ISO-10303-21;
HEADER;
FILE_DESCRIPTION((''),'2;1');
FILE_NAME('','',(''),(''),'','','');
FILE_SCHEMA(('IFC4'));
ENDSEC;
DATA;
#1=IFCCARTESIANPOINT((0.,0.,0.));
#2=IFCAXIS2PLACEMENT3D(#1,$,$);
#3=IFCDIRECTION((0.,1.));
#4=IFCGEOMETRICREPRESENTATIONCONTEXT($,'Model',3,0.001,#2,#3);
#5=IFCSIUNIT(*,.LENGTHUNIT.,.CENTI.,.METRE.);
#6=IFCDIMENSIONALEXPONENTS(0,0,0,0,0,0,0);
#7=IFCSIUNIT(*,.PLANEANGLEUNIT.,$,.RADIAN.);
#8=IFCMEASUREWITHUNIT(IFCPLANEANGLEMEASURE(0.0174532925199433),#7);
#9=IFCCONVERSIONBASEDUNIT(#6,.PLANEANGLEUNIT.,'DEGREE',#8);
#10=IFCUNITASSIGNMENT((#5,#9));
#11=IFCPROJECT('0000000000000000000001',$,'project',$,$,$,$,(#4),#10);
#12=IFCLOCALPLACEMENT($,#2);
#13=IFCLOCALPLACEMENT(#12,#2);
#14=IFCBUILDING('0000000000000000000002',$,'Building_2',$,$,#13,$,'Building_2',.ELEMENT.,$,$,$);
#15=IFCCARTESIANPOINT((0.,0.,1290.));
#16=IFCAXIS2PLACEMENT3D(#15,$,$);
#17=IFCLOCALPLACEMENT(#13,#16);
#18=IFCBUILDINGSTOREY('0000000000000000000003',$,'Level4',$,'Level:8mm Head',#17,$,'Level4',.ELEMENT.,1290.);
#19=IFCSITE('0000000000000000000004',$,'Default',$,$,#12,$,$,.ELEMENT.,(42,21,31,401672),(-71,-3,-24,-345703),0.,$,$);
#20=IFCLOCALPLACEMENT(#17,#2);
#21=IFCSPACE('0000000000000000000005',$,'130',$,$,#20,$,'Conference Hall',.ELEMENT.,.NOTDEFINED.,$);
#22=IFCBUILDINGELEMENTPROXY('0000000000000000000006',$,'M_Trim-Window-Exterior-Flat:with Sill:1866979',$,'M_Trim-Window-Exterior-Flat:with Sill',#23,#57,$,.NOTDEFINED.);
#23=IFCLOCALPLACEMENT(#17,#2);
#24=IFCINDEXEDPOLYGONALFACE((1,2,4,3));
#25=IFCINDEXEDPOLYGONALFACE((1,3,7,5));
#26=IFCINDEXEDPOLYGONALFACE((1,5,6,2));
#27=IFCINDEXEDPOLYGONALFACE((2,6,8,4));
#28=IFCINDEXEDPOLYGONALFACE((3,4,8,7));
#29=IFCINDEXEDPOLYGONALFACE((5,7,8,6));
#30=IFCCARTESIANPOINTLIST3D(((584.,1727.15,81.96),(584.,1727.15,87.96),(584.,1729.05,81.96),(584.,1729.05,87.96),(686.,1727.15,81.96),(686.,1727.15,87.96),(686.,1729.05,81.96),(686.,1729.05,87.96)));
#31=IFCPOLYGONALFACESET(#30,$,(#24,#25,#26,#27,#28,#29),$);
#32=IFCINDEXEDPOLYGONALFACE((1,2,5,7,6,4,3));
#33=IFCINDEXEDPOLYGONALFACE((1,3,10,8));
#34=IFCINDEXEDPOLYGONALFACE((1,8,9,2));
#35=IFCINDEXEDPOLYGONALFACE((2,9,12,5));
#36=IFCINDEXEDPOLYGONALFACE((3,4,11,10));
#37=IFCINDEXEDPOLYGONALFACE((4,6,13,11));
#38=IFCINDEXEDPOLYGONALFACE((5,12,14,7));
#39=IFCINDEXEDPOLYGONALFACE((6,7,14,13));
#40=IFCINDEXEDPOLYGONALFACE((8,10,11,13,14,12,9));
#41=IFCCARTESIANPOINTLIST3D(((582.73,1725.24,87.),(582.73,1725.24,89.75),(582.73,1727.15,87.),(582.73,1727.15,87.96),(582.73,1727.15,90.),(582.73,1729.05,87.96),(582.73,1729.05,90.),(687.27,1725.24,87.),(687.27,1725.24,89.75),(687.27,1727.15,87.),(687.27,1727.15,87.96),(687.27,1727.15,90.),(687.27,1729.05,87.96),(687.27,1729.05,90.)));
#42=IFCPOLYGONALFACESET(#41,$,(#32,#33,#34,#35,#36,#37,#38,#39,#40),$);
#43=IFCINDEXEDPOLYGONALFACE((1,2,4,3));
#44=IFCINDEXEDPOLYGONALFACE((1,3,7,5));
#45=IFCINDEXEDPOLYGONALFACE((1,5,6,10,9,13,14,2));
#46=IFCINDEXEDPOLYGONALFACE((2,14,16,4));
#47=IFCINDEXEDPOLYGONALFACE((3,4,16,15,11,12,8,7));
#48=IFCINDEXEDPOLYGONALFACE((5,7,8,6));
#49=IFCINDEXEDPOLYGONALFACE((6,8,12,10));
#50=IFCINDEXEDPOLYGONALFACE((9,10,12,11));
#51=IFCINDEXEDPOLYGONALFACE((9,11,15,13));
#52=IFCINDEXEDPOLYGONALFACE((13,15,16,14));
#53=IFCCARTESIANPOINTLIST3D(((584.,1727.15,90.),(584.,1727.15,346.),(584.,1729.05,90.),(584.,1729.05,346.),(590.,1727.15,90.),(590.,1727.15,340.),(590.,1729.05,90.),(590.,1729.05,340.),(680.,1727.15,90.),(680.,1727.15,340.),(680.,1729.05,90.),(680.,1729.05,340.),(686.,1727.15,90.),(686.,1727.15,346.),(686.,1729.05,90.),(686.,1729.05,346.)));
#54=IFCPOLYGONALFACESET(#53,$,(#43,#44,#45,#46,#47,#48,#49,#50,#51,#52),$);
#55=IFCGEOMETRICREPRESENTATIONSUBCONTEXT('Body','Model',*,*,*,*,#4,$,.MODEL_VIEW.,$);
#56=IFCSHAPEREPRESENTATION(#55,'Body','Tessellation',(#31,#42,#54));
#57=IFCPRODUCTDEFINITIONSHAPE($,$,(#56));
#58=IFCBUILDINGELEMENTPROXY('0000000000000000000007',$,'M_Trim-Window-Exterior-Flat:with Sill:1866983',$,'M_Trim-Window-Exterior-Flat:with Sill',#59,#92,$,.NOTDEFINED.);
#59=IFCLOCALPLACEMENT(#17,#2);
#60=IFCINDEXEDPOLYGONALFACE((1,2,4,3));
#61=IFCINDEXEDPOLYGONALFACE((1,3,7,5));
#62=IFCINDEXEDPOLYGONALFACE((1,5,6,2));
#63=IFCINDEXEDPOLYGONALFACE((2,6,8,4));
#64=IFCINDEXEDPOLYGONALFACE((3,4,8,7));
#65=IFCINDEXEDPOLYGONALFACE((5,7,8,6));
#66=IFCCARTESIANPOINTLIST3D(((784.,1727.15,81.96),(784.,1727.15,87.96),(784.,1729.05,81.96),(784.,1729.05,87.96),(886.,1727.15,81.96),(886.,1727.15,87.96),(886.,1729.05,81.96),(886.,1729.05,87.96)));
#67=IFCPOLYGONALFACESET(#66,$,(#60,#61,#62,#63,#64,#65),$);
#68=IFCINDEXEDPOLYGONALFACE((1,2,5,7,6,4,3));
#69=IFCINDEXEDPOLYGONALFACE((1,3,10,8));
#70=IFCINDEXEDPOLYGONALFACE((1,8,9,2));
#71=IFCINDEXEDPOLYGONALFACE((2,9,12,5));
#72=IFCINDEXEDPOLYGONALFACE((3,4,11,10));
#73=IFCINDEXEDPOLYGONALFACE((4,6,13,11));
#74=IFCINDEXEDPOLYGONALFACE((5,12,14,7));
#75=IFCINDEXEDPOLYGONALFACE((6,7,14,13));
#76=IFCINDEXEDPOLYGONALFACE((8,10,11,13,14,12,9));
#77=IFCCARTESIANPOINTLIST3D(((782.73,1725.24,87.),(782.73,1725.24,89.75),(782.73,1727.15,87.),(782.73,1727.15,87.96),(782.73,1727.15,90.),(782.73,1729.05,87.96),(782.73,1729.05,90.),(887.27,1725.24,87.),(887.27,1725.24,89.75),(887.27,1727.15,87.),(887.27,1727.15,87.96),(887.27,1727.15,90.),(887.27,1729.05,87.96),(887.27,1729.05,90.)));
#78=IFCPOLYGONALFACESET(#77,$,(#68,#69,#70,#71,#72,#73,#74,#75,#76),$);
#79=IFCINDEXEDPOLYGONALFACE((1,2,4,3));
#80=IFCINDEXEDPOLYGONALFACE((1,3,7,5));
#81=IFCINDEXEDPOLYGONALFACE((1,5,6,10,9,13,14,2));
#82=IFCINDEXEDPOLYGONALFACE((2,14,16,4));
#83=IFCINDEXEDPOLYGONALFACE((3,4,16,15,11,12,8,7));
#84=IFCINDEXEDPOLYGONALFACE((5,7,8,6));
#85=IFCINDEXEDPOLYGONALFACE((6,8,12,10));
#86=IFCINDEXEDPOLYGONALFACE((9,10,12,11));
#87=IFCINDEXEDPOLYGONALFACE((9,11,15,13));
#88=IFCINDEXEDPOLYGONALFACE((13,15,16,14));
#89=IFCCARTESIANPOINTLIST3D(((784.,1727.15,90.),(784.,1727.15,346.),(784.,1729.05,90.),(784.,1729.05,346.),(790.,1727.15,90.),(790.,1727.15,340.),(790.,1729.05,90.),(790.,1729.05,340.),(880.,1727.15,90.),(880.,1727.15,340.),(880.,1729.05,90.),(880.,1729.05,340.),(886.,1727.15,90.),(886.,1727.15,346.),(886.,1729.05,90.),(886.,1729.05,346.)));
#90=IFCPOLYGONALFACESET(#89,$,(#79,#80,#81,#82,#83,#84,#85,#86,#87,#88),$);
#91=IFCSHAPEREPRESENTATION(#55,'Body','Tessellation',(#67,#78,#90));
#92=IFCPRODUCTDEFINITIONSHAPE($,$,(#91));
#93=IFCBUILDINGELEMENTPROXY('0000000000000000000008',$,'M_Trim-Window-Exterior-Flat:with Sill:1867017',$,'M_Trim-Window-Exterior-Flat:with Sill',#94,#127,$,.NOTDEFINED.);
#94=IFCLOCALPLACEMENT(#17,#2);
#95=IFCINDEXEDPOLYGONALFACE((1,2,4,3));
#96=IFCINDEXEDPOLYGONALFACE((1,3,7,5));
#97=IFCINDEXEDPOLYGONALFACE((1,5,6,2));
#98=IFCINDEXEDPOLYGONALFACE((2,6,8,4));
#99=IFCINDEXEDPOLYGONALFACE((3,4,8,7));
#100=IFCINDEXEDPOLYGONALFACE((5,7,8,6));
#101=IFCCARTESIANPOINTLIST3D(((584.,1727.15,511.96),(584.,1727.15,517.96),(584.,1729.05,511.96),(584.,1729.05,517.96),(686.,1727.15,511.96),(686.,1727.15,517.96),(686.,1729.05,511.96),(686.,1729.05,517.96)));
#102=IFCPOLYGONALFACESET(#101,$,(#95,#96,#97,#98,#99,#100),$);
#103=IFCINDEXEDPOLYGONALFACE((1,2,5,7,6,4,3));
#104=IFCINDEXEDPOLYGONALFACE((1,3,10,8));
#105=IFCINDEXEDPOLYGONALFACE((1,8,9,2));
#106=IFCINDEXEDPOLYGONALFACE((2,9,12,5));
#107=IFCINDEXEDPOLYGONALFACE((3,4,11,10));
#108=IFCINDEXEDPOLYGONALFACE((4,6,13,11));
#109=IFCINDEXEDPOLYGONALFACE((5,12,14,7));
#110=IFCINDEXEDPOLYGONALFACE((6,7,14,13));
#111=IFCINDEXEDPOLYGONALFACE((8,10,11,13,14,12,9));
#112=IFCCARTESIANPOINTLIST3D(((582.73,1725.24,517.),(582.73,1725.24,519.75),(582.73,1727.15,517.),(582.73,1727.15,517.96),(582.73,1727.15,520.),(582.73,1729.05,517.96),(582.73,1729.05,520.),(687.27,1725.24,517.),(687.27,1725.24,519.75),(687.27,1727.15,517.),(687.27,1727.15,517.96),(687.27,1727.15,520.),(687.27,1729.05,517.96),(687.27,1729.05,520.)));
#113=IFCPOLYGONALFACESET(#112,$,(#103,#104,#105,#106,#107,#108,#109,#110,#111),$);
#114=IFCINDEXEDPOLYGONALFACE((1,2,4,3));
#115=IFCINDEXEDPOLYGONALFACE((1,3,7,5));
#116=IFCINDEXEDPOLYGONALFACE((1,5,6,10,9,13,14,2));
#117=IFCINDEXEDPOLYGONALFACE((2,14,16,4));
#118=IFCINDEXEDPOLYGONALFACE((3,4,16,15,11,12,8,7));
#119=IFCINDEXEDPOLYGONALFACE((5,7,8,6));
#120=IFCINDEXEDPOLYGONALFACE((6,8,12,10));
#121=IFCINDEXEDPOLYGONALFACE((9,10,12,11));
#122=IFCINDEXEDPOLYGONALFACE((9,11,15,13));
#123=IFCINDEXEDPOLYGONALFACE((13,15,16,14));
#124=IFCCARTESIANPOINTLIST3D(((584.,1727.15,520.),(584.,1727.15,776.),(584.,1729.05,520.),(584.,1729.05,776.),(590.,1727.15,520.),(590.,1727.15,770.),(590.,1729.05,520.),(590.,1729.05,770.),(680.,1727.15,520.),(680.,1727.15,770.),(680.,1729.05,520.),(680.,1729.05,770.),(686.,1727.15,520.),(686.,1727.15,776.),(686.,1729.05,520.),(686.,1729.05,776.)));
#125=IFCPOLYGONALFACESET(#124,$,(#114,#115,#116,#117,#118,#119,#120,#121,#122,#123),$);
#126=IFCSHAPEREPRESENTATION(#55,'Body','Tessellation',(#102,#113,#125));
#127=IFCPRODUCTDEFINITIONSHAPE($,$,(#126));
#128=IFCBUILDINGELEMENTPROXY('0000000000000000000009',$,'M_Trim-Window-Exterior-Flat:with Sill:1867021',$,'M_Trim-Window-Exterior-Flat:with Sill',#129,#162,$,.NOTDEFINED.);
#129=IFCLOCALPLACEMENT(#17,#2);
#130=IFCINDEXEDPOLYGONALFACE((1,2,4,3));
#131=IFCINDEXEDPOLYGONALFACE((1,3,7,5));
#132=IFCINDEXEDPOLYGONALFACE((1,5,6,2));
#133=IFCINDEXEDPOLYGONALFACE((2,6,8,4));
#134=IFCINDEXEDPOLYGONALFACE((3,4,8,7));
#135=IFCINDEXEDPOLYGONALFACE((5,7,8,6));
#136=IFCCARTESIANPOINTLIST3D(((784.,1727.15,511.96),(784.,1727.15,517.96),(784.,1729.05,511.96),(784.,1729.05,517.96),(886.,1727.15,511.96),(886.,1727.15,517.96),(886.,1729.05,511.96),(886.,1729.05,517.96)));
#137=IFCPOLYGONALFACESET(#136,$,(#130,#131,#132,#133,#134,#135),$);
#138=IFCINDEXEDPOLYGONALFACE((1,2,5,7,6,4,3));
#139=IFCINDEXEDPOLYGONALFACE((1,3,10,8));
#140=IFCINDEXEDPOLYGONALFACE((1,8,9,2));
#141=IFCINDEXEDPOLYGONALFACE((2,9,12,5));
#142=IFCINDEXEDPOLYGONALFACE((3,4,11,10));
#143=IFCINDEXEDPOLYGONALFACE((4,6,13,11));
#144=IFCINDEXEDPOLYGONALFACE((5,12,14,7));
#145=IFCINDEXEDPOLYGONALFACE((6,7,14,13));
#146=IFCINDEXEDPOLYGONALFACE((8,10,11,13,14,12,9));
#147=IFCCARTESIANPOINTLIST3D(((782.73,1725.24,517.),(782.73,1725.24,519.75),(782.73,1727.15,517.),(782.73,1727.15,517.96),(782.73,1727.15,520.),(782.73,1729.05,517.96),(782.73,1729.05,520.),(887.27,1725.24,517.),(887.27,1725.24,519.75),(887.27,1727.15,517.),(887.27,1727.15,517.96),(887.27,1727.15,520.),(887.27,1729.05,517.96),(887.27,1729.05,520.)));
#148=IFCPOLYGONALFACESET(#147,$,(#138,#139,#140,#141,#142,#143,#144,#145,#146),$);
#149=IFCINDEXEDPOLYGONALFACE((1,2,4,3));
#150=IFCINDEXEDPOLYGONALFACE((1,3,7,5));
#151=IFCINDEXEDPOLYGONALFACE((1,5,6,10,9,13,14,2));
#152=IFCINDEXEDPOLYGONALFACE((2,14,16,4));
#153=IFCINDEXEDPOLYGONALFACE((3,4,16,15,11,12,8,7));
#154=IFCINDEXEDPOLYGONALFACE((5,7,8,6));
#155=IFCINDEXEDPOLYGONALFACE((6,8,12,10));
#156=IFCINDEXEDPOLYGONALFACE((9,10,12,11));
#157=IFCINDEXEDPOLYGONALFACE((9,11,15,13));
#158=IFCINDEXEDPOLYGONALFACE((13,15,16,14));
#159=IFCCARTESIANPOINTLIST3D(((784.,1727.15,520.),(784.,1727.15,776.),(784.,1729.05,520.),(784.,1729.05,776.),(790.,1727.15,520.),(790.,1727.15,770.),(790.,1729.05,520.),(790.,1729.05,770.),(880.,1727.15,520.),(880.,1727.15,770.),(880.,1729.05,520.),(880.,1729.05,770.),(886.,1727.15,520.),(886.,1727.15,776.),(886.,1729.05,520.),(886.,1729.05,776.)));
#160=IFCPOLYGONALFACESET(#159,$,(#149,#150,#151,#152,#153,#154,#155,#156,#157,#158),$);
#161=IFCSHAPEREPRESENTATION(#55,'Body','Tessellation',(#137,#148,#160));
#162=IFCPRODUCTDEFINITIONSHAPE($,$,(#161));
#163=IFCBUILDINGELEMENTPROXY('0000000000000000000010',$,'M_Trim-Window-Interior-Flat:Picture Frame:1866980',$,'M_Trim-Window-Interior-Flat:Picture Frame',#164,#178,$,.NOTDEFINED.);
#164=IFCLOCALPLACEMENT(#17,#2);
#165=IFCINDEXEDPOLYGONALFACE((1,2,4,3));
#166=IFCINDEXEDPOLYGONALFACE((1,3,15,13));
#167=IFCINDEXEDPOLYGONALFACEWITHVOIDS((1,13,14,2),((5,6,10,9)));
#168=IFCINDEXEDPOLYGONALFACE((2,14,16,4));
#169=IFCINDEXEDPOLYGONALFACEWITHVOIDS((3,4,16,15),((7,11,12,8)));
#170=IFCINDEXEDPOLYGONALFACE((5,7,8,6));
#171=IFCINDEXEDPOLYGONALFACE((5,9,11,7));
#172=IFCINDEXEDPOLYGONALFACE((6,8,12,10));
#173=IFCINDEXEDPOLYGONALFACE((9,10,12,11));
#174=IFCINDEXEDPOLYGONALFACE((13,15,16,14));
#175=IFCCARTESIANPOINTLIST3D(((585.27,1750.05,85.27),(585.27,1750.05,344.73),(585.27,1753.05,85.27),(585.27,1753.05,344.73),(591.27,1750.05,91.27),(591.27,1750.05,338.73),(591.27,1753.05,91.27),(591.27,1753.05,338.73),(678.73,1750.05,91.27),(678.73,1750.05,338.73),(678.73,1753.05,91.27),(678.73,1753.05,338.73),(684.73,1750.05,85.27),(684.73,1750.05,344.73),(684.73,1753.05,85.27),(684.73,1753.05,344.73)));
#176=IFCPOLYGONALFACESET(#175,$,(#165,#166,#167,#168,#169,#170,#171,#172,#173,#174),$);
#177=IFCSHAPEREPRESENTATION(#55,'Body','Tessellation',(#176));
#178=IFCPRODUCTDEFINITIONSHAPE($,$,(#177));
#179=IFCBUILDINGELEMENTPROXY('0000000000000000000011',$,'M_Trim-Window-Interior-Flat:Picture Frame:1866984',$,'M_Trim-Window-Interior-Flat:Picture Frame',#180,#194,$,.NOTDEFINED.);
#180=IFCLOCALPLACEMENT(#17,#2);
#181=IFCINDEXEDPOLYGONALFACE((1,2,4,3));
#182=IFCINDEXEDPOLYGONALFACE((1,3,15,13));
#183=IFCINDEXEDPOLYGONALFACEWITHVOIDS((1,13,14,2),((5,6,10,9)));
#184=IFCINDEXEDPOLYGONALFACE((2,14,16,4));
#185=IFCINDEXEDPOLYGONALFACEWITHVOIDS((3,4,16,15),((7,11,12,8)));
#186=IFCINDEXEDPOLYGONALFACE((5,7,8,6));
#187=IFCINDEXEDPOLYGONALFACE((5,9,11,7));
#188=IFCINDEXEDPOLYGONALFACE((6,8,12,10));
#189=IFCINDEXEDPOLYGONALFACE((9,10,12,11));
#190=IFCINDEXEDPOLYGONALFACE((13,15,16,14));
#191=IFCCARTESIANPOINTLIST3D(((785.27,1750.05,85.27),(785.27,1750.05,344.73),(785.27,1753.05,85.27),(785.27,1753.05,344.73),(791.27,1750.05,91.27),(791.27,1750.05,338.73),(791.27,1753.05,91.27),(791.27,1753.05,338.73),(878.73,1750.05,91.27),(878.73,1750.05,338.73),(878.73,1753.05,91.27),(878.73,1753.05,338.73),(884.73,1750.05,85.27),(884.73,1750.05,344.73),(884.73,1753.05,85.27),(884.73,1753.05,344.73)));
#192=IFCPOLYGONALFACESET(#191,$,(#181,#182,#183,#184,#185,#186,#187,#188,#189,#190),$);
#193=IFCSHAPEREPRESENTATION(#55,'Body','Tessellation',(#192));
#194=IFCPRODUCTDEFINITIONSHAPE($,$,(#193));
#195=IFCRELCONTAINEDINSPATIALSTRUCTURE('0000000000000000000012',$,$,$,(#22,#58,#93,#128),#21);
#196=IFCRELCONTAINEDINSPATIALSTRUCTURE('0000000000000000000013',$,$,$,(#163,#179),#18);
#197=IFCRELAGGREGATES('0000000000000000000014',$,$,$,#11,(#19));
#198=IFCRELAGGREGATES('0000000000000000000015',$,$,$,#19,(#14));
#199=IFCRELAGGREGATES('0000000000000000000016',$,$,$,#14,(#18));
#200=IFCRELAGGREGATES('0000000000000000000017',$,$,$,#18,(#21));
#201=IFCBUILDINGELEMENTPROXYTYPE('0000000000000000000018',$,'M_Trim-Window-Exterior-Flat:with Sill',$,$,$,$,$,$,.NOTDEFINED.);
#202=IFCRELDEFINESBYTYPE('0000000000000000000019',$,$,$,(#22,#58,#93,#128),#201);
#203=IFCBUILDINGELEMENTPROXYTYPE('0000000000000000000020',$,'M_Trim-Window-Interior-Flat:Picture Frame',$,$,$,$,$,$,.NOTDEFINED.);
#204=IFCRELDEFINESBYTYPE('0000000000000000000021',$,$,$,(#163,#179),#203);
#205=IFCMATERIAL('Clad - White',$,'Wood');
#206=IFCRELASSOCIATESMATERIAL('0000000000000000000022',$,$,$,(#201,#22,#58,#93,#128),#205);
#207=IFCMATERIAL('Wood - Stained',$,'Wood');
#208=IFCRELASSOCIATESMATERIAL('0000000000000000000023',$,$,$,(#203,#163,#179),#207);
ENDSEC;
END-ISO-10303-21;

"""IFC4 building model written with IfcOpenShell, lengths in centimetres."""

from ifc_helpers import new_model, entity, si_unit, converted_unit, direction, frame, origin, place, context, subcontext, project, spatial, indexed_curve, outline, extrude, source, transform, mapped, material, type_object, type_shapes, element, save


model = new_model("IFC4")

# Units and contexts
model_context = context("Model", 3, precision=0.001, world=origin(), true_north=direction((0.0, 1.0)))
body_context = subcontext(model_context, "Body", "Model", "MODEL_VIEW")
ifc_project = project(units=[si_unit("LENGTHUNIT", "METRE", prefix="CENTI"), converted_unit("PLANEANGLEUNIT", "DEGREE", entity("IfcPlaneAngleMeasure", 0.0174532925199433), si_unit("PLANEANGLEUNIT", "RADIAN"), dimensions=[0, 0, 0, 0, 0, 0, 0])], contexts=[model_context])

# Site, building, storey
site_placement = place(None, origin())
site = spatial("IfcSite", under=ifc_project, at=site_placement, Name="Default", CompositionType="ELEMENT", RefLatitude=(42, 21, 31, 401672), RefLongitude=(-71, -3, -24, -345703), RefElevation=0.0)
building_placement = place(site_placement, origin())
building = spatial("IfcBuilding", under=site, at=building_placement, Name="Building_2", LongName="Building_2", CompositionType="ELEMENT")
storey_placement = place(building_placement, frame((0.0, 0.0, 1290.0)))
storey = spatial("IfcBuildingStorey", under=building, at=storey_placement, Name="Level4", ObjectType="Level:8mm Head", LongName="Level4", CompositionType="ELEMENT", Elevation=1290.0)

# Shared definitions
ifc_material_1 = material(Name="Clad - White", Category="Wood")
ifc_material_2 = material(Name="Wood - Stained", Category="Wood")

# Shared definitions
space_1_placement = place(storey_placement, origin())
space_1 = spatial("IfcSpace", under=storey, at=space_1_placement, Name="130", LongName="Conference Hall", CompositionType="ELEMENT", PredefinedType="NOTDEFINED")

# Building element proxies
building_element_proxy_type_1 = type_object("IfcBuildingElementProxyType", Name="M_Trim-Window-Exterior-Flat:with Sill", PredefinedType="NOTDEFINED", material=ifc_material_1)
shared_shape_1 = source(origin(), body_context, "Body", "SweptSolid", [
    extrude(outline(indexed_curve([(-3.0, -51.0), (3.0, -51.0), (3.0, 51.0), (-3.0, 51.0), (-3.0, -51.0)], self_intersect=False)), frame((0.0, 255.04, 0.0), z_axis=(0.0, 0.0, 1.0), x_axis=(0.0, 1.0, 0.0)), (0.0, 0.0, 1.0), 1.91),
    extrude(outline(indexed_curve([(-1.52, -1.9), (1.23, -1.9), (1.48, 0.0), (1.48, 1.9), (-0.57, 1.9), (-0.57, 0.0), (-1.52, 0.0), (-1.52, -1.9)], self_intersect=False)), frame((-52.27, 251.48, 1.9), z_axis=(1.0, 0.0, 0.0), x_axis=(0.0, -1.0, 0.0)), (0.0, 0.0, 1.0), 104.54),
    extrude(outline(indexed_curve([(-51.0, -129.5), (51.0, -129.5), (51.0, 126.5), (45.0, 126.5), (45.0, -123.5), (-45.0, -123.5), (-45.0, 126.5), (-51.0, 126.5), (-51.0, -129.5)], self_intersect=False)), frame((0.0, 123.5, 0.0)), (0.0, 0.0, 1.0), 1.91),
])
type_shapes(building_element_proxy_type_1, [shared_shape_1])
for number, where, z_axis, x_axis, name in (
    (1, (635.0, 1729.05, 340.0), (0.0, -1.0, 0.0), (-1.0, 0.0, 0.0), "M_Trim-Window-Exterior-Flat:with Sill:1866979"),
    (2, (835.0, 1729.05, 340.0), (0.0, -1.0, 0.0), (-1.0, 0.0, 0.0), "M_Trim-Window-Exterior-Flat:with Sill:1866983"),
    (3, (635.0, 1729.05, 770.0), (0.0, -1.0, 0.0), (-1.0, 0.0, 0.0), "M_Trim-Window-Exterior-Flat:with Sill:1867017"),
    (4, (835.0, 1729.05, 770.0), (0.0, -1.0, 0.0), (-1.0, 0.0, 0.0), "M_Trim-Window-Exterior-Flat:with Sill:1867021"),
):
    element("IfcBuildingElementProxy", number, at=place(space_1_placement, frame(where, z_axis=z_axis, x_axis=x_axis)), inside=space_1, type_object=building_element_proxy_type_1, material=ifc_material_1, Name=name, ObjectType="M_Trim-Window-Exterior-Flat:with Sill", PredefinedType="NOTDEFINED", context=body_context, shape_type="MappedRepresentation", body=[
        mapped(shared_shape_1, transform((0.0, 0.0, 0.0), scale=1.0)),
    ])
building_element_proxy_type_2 = type_object("IfcBuildingElementProxyType", Name="M_Trim-Window-Interior-Flat:Picture Frame", PredefinedType="NOTDEFINED", material=ifc_material_2)
shared_shape_2 = source(origin(), body_context, "Body", "SweptSolid", [
    extrude(outline(indexed_curve([(-129.73, -49.73), (129.73, -49.73), (129.73, 49.73), (-129.73, 49.73), (-129.73, -49.73)], self_intersect=False), holes=[indexed_curve([(-123.73, -43.73), (-123.73, 43.73), (123.73, 43.73), (123.73, -43.73), (-123.73, -43.73)], self_intersect=False)]), frame((0.0, 125.0, 0.0), z_axis=(0.0, 0.0, 1.0), x_axis=(0.0, 1.0, 0.0)), (0.0, 0.0, 1.0), 3.0),
])
type_shapes(building_element_proxy_type_2, [shared_shape_2])
for number, where, z_axis, x_axis, name in (
    (5, (635.0, 1750.05, 340.0), (0.0, 1.0, 0.0), (1.0, 0.0, 0.0), "M_Trim-Window-Interior-Flat:Picture Frame:1866980"),
    (6, (835.0, 1750.05, 340.0), (0.0, 1.0, 0.0), (1.0, 0.0, 0.0), "M_Trim-Window-Interior-Flat:Picture Frame:1866984"),
):
    element("IfcBuildingElementProxy", number, at=place(storey_placement, frame(where, z_axis=z_axis, x_axis=x_axis)), inside=storey, type_object=building_element_proxy_type_2, material=ifc_material_2, Name=name, ObjectType="M_Trim-Window-Interior-Flat:Picture Frame", PredefinedType="NOTDEFINED", context=body_context, shape_type="MappedRepresentation", body=[
        mapped(shared_shape_2, transform((0.0, 0.0, 0.0), scale=1.0)),
    ])

save(model, "model.ifc")
